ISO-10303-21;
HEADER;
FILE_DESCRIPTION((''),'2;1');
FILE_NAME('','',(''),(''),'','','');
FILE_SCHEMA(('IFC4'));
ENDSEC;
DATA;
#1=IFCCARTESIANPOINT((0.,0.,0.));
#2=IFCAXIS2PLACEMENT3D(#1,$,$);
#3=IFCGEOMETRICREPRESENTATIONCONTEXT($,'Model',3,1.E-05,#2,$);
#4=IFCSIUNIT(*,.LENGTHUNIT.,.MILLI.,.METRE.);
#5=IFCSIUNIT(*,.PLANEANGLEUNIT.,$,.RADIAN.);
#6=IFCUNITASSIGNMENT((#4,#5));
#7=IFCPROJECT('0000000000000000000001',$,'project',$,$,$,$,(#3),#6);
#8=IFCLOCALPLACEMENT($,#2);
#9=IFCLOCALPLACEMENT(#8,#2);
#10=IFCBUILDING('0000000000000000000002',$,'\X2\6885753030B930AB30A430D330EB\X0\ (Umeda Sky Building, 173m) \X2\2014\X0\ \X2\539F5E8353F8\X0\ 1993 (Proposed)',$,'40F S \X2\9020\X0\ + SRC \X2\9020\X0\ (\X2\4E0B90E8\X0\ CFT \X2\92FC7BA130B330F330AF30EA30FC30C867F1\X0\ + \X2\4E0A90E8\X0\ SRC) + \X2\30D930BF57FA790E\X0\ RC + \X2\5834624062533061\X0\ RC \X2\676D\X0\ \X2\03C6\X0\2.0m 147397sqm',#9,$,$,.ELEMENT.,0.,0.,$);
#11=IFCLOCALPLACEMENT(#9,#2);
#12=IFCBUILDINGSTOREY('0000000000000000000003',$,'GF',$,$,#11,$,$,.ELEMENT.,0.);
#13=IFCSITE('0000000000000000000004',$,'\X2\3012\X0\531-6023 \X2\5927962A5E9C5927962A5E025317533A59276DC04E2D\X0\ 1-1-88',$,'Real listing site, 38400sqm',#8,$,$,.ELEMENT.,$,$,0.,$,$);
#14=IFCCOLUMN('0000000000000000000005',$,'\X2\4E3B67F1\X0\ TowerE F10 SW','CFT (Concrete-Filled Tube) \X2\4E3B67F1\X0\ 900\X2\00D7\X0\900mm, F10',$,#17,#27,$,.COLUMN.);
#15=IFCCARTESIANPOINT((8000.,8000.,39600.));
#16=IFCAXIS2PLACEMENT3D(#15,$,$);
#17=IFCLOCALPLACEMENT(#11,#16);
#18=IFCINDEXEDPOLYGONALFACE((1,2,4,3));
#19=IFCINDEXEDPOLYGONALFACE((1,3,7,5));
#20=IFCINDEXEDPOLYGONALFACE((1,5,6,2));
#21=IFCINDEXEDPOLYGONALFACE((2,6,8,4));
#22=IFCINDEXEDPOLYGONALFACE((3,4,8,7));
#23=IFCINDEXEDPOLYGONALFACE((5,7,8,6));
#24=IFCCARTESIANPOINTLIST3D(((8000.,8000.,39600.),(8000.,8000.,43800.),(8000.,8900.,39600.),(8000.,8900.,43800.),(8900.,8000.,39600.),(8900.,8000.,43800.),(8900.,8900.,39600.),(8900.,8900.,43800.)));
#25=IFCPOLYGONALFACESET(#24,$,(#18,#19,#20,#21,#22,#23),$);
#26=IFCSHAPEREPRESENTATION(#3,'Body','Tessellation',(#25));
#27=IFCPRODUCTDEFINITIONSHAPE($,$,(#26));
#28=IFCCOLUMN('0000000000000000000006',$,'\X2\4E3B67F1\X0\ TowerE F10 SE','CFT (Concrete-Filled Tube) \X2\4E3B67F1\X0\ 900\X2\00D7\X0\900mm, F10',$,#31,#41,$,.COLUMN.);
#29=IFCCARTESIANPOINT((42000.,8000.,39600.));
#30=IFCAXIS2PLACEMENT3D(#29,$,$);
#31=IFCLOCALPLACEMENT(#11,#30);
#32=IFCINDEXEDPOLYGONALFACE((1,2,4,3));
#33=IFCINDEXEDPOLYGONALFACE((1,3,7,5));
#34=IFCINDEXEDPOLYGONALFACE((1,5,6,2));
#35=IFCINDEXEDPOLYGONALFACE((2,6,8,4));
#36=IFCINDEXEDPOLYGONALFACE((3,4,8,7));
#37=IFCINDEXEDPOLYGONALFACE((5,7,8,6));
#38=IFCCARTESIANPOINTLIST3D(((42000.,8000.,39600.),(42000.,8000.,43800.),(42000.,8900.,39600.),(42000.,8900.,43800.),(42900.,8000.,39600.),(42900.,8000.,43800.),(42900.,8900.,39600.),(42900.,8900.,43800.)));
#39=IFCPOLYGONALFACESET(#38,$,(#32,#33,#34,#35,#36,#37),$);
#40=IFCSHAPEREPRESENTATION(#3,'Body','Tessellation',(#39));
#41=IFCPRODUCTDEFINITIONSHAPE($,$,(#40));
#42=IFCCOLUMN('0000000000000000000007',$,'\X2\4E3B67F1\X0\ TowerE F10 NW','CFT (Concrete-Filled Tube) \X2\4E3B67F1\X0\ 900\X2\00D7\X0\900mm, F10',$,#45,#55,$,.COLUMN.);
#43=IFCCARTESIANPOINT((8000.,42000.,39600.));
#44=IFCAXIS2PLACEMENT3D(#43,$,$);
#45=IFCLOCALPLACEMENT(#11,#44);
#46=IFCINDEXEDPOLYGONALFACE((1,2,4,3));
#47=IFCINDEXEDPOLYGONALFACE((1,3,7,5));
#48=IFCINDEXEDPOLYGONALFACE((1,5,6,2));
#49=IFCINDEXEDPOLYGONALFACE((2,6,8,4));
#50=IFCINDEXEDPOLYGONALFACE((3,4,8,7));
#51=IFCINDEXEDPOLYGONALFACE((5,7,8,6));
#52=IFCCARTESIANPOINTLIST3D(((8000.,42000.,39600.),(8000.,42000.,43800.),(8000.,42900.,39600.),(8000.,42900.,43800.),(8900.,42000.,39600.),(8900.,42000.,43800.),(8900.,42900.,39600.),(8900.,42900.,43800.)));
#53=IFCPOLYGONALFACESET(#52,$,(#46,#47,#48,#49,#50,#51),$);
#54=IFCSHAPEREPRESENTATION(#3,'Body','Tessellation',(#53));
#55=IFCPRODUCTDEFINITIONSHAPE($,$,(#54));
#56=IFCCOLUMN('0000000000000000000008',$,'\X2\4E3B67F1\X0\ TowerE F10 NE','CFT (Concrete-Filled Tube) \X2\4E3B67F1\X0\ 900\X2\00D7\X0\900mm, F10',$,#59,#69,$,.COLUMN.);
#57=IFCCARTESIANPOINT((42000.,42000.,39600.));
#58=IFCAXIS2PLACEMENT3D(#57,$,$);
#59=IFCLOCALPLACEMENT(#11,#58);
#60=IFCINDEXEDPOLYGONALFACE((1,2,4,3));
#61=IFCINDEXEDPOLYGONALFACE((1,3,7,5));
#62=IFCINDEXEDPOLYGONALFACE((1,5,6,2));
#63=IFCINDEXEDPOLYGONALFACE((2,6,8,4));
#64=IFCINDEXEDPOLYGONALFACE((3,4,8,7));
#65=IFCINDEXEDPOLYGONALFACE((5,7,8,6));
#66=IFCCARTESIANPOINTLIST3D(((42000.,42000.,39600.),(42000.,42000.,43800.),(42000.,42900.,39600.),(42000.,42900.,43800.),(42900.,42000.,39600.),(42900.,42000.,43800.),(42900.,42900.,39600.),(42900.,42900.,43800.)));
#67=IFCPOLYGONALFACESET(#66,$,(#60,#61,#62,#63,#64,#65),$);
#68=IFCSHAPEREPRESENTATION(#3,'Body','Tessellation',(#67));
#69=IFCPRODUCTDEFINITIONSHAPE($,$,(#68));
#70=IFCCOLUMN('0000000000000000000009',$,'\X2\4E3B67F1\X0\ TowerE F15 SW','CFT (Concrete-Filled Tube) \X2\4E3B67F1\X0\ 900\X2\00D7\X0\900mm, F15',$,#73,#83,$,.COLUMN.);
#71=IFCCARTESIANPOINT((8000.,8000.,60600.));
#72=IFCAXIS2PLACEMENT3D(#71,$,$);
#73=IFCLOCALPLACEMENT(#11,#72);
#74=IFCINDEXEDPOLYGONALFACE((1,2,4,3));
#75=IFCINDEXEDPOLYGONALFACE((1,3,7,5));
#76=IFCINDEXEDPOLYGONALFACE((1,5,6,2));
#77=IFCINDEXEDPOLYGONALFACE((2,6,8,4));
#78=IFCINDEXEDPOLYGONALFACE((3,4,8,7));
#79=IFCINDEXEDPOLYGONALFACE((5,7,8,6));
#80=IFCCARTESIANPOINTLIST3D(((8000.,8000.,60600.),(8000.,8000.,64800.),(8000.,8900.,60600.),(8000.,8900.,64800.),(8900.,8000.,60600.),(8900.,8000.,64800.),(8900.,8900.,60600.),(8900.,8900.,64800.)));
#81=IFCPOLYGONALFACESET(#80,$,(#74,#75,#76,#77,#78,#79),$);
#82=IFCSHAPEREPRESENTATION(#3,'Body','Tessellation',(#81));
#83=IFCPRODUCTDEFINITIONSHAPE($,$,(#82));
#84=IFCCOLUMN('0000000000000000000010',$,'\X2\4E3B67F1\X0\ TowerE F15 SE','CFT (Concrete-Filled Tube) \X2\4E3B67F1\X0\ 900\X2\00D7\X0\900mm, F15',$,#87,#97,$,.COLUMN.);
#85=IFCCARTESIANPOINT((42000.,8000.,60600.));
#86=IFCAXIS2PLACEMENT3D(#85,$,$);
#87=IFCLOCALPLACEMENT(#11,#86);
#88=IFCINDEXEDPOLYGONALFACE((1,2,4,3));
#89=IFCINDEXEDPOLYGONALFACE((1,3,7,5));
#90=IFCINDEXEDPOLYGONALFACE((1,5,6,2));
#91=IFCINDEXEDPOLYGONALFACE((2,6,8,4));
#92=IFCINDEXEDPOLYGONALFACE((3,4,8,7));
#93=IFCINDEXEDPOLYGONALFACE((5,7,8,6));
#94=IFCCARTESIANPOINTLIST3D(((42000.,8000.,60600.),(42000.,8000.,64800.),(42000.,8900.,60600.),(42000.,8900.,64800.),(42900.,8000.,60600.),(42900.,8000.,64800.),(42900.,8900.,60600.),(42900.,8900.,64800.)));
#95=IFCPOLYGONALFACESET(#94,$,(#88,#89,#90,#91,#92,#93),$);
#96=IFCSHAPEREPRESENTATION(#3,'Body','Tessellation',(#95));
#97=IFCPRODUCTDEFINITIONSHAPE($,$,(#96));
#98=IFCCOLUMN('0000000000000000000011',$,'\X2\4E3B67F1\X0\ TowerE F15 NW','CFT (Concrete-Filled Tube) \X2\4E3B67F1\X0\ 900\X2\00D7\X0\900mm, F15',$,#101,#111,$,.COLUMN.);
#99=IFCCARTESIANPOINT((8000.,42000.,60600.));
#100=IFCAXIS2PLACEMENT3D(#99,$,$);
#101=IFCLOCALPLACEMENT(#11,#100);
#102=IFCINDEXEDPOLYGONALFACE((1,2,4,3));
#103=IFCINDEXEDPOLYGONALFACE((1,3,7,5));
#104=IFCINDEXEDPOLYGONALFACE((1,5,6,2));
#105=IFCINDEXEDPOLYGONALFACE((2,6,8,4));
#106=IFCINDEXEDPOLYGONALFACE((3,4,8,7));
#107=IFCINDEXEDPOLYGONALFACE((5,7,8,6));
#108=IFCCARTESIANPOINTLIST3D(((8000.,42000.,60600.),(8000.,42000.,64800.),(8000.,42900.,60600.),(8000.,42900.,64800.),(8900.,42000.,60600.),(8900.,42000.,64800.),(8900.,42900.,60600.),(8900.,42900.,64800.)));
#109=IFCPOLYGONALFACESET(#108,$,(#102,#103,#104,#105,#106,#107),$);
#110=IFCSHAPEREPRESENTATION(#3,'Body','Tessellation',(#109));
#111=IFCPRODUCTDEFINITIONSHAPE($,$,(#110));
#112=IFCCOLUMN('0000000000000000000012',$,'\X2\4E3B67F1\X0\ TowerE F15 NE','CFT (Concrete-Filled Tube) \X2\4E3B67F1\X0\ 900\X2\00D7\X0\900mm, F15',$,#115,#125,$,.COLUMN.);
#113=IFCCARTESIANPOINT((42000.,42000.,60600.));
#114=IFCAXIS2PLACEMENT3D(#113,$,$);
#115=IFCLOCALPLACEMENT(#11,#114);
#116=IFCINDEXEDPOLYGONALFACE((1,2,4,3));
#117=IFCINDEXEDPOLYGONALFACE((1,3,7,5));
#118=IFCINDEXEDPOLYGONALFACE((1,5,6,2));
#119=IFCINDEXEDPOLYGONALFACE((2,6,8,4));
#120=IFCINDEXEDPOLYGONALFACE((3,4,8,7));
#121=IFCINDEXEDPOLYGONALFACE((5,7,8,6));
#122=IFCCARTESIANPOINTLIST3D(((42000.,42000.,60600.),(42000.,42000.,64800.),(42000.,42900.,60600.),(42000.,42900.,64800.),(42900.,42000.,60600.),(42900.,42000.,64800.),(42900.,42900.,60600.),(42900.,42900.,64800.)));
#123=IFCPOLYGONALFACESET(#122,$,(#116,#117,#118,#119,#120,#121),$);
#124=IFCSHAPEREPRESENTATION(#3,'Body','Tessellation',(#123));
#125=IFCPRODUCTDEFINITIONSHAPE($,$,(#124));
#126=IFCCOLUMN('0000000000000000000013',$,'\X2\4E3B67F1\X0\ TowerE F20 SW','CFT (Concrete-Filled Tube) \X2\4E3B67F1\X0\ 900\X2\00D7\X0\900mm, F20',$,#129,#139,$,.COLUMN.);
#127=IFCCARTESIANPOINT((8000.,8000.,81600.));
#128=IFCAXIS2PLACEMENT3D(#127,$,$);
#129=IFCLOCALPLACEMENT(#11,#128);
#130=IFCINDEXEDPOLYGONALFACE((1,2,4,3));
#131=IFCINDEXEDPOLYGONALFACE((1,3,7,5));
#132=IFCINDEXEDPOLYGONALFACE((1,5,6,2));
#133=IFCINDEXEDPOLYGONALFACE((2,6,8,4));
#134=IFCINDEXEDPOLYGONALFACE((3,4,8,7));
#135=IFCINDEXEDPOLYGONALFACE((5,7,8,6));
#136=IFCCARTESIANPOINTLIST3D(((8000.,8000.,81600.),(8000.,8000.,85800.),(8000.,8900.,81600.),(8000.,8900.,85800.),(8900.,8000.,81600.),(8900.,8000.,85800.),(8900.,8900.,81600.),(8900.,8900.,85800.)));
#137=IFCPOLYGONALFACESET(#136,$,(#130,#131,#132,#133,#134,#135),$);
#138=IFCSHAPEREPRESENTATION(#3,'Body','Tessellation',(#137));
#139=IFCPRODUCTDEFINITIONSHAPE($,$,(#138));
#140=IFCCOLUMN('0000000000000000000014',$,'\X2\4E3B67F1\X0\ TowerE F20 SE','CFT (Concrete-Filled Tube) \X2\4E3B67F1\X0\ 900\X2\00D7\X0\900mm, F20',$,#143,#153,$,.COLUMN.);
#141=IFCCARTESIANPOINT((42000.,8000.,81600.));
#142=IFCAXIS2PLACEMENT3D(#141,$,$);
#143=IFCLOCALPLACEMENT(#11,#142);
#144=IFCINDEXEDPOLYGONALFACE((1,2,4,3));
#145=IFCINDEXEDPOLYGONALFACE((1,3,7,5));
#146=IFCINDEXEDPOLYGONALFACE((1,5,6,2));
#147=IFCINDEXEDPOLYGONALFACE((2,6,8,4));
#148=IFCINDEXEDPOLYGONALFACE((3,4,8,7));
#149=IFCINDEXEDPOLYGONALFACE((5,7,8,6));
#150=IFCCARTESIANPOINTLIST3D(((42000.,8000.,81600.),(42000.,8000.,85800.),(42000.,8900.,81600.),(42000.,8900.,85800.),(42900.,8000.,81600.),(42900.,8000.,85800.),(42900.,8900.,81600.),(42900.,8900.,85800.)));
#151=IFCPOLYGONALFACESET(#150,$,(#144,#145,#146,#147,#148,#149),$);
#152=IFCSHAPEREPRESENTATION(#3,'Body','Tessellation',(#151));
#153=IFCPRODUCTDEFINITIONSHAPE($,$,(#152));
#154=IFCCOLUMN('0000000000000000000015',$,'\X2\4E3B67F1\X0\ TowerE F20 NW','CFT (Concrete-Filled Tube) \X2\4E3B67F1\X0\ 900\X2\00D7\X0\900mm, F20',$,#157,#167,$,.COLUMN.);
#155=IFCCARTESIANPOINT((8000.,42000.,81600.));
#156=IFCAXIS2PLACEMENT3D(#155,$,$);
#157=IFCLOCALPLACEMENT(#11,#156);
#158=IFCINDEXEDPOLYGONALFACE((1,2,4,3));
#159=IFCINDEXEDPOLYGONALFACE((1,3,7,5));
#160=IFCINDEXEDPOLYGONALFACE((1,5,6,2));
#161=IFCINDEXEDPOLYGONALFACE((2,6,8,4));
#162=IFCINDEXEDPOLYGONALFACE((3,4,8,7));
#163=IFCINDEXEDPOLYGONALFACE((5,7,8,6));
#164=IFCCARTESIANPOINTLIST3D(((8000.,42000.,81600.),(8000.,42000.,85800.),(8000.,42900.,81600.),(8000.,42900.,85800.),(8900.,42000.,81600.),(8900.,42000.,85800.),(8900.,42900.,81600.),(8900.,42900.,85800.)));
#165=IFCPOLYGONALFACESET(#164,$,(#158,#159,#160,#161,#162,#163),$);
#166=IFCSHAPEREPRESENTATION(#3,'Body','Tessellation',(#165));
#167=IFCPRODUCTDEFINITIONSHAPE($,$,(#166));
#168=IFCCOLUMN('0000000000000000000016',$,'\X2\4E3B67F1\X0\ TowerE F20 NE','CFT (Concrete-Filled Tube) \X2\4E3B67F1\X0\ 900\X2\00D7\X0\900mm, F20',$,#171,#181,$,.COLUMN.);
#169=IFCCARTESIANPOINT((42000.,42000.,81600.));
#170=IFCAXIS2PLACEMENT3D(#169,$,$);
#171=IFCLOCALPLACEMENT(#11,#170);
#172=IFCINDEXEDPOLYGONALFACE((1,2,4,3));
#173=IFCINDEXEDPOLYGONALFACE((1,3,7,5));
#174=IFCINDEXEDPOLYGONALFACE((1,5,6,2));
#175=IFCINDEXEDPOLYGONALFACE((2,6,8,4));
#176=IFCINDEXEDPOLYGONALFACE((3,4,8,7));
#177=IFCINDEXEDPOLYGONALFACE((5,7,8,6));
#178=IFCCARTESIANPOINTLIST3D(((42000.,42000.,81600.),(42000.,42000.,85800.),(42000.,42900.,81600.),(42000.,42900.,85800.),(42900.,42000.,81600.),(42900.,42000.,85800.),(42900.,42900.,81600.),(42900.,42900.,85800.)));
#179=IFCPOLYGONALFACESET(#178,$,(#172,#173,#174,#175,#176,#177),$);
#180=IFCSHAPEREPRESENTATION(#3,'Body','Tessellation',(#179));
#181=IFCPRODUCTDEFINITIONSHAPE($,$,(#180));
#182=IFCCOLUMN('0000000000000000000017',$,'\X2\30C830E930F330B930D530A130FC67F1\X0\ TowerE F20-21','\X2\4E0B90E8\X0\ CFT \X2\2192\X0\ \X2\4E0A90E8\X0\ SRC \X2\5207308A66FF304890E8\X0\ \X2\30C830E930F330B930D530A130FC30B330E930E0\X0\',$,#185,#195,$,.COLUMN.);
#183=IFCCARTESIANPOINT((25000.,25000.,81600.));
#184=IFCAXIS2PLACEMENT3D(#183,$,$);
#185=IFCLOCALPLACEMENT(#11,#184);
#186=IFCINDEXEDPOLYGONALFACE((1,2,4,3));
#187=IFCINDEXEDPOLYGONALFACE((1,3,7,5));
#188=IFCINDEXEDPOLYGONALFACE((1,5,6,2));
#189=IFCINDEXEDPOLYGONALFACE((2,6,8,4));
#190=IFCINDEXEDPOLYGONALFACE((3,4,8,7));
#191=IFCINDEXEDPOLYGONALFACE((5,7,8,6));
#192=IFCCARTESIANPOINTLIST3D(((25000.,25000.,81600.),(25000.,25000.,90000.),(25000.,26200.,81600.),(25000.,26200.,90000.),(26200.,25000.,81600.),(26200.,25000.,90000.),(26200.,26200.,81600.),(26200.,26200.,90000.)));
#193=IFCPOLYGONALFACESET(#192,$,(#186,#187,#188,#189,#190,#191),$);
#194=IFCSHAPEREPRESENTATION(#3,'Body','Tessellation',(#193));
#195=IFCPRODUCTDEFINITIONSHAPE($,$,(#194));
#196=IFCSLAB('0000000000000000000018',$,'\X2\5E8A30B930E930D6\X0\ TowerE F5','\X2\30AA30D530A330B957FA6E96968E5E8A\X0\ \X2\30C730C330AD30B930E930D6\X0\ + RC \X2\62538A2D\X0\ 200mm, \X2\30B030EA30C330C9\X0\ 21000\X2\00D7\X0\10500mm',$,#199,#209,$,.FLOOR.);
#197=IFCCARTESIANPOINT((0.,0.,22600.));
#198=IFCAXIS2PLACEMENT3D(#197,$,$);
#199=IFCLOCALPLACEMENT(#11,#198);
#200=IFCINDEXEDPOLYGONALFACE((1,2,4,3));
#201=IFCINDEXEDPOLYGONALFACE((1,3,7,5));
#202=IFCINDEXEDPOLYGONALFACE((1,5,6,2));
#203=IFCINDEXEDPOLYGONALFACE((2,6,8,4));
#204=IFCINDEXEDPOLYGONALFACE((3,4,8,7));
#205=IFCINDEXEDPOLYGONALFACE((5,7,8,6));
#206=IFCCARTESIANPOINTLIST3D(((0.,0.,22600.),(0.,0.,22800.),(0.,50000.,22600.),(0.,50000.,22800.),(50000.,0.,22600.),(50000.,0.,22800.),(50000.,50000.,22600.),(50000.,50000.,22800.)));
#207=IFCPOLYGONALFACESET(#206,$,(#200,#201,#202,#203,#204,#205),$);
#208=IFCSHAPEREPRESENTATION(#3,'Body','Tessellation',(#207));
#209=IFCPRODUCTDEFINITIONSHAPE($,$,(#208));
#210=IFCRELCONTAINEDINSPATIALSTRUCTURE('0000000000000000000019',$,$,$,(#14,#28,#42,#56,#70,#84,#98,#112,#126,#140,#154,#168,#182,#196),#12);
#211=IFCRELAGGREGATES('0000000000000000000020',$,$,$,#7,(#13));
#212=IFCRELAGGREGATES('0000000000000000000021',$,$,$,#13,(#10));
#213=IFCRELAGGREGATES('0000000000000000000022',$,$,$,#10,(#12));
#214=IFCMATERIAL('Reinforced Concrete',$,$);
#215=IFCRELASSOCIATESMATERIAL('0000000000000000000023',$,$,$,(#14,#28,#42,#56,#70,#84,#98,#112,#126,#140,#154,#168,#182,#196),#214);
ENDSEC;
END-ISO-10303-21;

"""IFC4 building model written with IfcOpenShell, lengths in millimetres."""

from ifc_helpers import new_model, si_unit, frame, frame_2d, origin, place, context, project, spatial, rectangle, extrude, material, element, save


model = new_model("IFC4")

# Units and contexts
model_context = context("Model", 3, precision=1e-05, world=origin())
ifc_project = project(units=[si_unit("LENGTHUNIT", "METRE", prefix="MILLI"), si_unit("PLANEANGLEUNIT", "RADIAN")], contexts=[model_context])

# Site, building, storey
site_placement = place(None, origin())
site = spatial("IfcSite", under=ifc_project, at=site_placement, Name="〒531-6023 大阪府大阪市北区大淀中 1-1-88", ObjectType="Real listing site, 38400sqm", CompositionType="ELEMENT", RefElevation=0.0)
building_placement = place(site_placement, origin())
building = spatial("IfcBuilding", under=site, at=building_placement, Name="梅田スカイビル (Umeda Sky Building, 173m) — 原広司 1993 (Proposed)", ObjectType="40F S 造 + SRC 造 (下部 CFT 鋼管コンクリート柱 + 上部 SRC) + ベタ基礎 RC + 場所打ち RC 杭 φ2.0m 147397sqm", CompositionType="ELEMENT", ElevationOfRefHeight=0.0, ElevationOfTerrain=0.0)
storey_placement = place(building_placement, origin())
storey = spatial("IfcBuildingStorey", under=building, at=storey_placement, Name="GF", CompositionType="ELEMENT", Elevation=0.0)

# Columns
ifc_material_1 = material(Name="Reinforced Concrete")
column_1_placement = place(storey_placement, frame((8000.0, 8000.0, 39600.0)))
element("IfcColumn", 1, at=column_1_placement, inside=storey, material=ifc_material_1, Name="主柱 TowerE F10 SW", Description="CFT (Concrete-Filled Tube) 主柱 900×900mm, F10", PredefinedType="COLUMN", context=model_context, shape_type="SweptSolid", body=[
    extrude(rectangle(XDim=900.0, YDim=900.0, at=frame_2d((450.0, 450.0))), frame((8000.0, 8000.0, 39600.0)), (0.0, 0.0, 1.0), 4200.0),
])
column_2_placement = place(storey_placement, frame((42000.0, 8000.0, 39600.0)))
element("IfcColumn", 2, at=column_2_placement, inside=storey, material=ifc_material_1, Name="主柱 TowerE F10 SE", Description="CFT (Concrete-Filled Tube) 主柱 900×900mm, F10", PredefinedType="COLUMN", context=model_context, shape_type="SweptSolid", body=[
    extrude(rectangle(XDim=900.0, YDim=900.0, at=frame_2d((450.0, 450.0))), frame((42000.0, 8000.0, 39600.0)), (0.0, 0.0, 1.0), 4200.0),
])
column_3_placement = place(storey_placement, frame((8000.0, 42000.0, 39600.0)))
element("IfcColumn", 3, at=column_3_placement, inside=storey, material=ifc_material_1, Name="主柱 TowerE F10 NW", Description="CFT (Concrete-Filled Tube) 主柱 900×900mm, F10", PredefinedType="COLUMN", context=model_context, shape_type="SweptSolid", body=[
    extrude(rectangle(XDim=900.0, YDim=900.0, at=frame_2d((450.0, 450.0))), frame((8000.0, 42000.0, 39600.0)), (0.0, 0.0, 1.0), 4200.0),
])
column_4_placement = place(storey_placement, frame((42000.0, 42000.0, 39600.0)))
element("IfcColumn", 4, at=column_4_placement, inside=storey, material=ifc_material_1, Name="主柱 TowerE F10 NE", Description="CFT (Concrete-Filled Tube) 主柱 900×900mm, F10", PredefinedType="COLUMN", context=model_context, shape_type="SweptSolid", body=[
    extrude(rectangle(XDim=900.0, YDim=900.0, at=frame_2d((450.0, 450.0))), frame((42000.0, 42000.0, 39600.0)), (0.0, 0.0, 1.0), 4200.0),
])
column_5_placement = place(storey_placement, frame((8000.0, 8000.0, 60600.0)))
element("IfcColumn", 5, at=column_5_placement, inside=storey, material=ifc_material_1, Name="主柱 TowerE F15 SW", Description="CFT (Concrete-Filled Tube) 主柱 900×900mm, F15", PredefinedType="COLUMN", context=model_context, shape_type="SweptSolid", body=[
    extrude(rectangle(XDim=900.0, YDim=900.0, at=frame_2d((450.0, 450.0))), frame((8000.0, 8000.0, 60600.0)), (0.0, 0.0, 1.0), 4200.0),
])
column_6_placement = place(storey_placement, frame((42000.0, 8000.0, 60600.0)))
element("IfcColumn", 6, at=column_6_placement, inside=storey, material=ifc_material_1, Name="主柱 TowerE F15 SE", Description="CFT (Concrete-Filled Tube) 主柱 900×900mm, F15", PredefinedType="COLUMN", context=model_context, shape_type="SweptSolid", body=[
    extrude(rectangle(XDim=900.0, YDim=900.0, at=frame_2d((450.0, 450.0))), frame((42000.0, 8000.0, 60600.0)), (0.0, 0.0, 1.0), 4200.0),
])
column_7_placement = place(storey_placement, frame((8000.0, 42000.0, 60600.0)))
element("IfcColumn", 7, at=column_7_placement, inside=storey, material=ifc_material_1, Name="主柱 TowerE F15 NW", Description="CFT (Concrete-Filled Tube) 主柱 900×900mm, F15", PredefinedType="COLUMN", context=model_context, shape_type="SweptSolid", body=[
    extrude(rectangle(XDim=900.0, YDim=900.0, at=frame_2d((450.0, 450.0))), frame((8000.0, 42000.0, 60600.0)), (0.0, 0.0, 1.0), 4200.0),
])
column_8_placement = place(storey_placement, frame((42000.0, 42000.0, 60600.0)))
element("IfcColumn", 8, at=column_8_placement, inside=storey, material=ifc_material_1, Name="主柱 TowerE F15 NE", Description="CFT (Concrete-Filled Tube) 主柱 900×900mm, F15", PredefinedType="COLUMN", context=model_context, shape_type="SweptSolid", body=[
    extrude(rectangle(XDim=900.0, YDim=900.0, at=frame_2d((450.0, 450.0))), frame((42000.0, 42000.0, 60600.0)), (0.0, 0.0, 1.0), 4200.0),
])
column_9_placement = place(storey_placement, frame((8000.0, 8000.0, 81600.0)))
element("IfcColumn", 9, at=column_9_placement, inside=storey, material=ifc_material_1, Name="主柱 TowerE F20 SW", Description="CFT (Concrete-Filled Tube) 主柱 900×900mm, F20", PredefinedType="COLUMN", context=model_context, shape_type="SweptSolid", body=[
    extrude(rectangle(XDim=900.0, YDim=900.0, at=frame_2d((450.0, 450.0))), frame((8000.0, 8000.0, 81600.0)), (0.0, 0.0, 1.0), 4200.0),
])
column_10_placement = place(storey_placement, frame((42000.0, 8000.0, 81600.0)))
element("IfcColumn", 10, at=column_10_placement, inside=storey, material=ifc_material_1, Name="主柱 TowerE F20 SE", Description="CFT (Concrete-Filled Tube) 主柱 900×900mm, F20", PredefinedType="COLUMN", context=model_context, shape_type="SweptSolid", body=[
    extrude(rectangle(XDim=900.0, YDim=900.0, at=frame_2d((450.0, 450.0))), frame((42000.0, 8000.0, 81600.0)), (0.0, 0.0, 1.0), 4200.0),
])
column_11_placement = place(storey_placement, frame((8000.0, 42000.0, 81600.0)))
element("IfcColumn", 11, at=column_11_placement, inside=storey, material=ifc_material_1, Name="主柱 TowerE F20 NW", Description="CFT (Concrete-Filled Tube) 主柱 900×900mm, F20", PredefinedType="COLUMN", context=model_context, shape_type="SweptSolid", body=[
    extrude(rectangle(XDim=900.0, YDim=900.0, at=frame_2d((450.0, 450.0))), frame((8000.0, 42000.0, 81600.0)), (0.0, 0.0, 1.0), 4200.0),
])
column_12_placement = place(storey_placement, frame((42000.0, 42000.0, 81600.0)))
element("IfcColumn", 12, at=column_12_placement, inside=storey, material=ifc_material_1, Name="主柱 TowerE F20 NE", Description="CFT (Concrete-Filled Tube) 主柱 900×900mm, F20", PredefinedType="COLUMN", context=model_context, shape_type="SweptSolid", body=[
    extrude(rectangle(XDim=900.0, YDim=900.0, at=frame_2d((450.0, 450.0))), frame((42000.0, 42000.0, 81600.0)), (0.0, 0.0, 1.0), 4200.0),
])
column_13_placement = place(storey_placement, frame((25000.0, 25000.0, 81600.0)))
element("IfcColumn", 13, at=column_13_placement, inside=storey, material=ifc_material_1, Name="トランスファー柱 TowerE F20-21", Description="下部 CFT → 上部 SRC 切り替え部 トランスファーコラム", PredefinedType="COLUMN", context=model_context, shape_type="SweptSolid", body=[
    extrude(rectangle(XDim=1200.0, YDim=1200.0, at=frame_2d((600.0, 600.0))), frame((25000.0, 25000.0, 81600.0)), (0.0, 0.0, 1.0), 8400.0),
])

# Slab
slab_1_placement = place(storey_placement, frame((0.0, 0.0, 22600.0)))
element("IfcSlab", 14, at=slab_1_placement, inside=storey, material=ifc_material_1, Name="床スラブ TowerE F5", Description="オフィス基準階床 デッキスラブ + RC 打設 200mm, グリッド 21000×10500mm", PredefinedType="FLOOR", context=model_context, shape_type="SweptSolid", body=[
    extrude(rectangle(XDim=50000.0, YDim=50000.0, at=frame_2d((25000.0, 25000.0))), frame((0.0, 0.0, 22600.0)), (0.0, 0.0, 1.0), 200.0),
])

save(model, "model.ifc")
